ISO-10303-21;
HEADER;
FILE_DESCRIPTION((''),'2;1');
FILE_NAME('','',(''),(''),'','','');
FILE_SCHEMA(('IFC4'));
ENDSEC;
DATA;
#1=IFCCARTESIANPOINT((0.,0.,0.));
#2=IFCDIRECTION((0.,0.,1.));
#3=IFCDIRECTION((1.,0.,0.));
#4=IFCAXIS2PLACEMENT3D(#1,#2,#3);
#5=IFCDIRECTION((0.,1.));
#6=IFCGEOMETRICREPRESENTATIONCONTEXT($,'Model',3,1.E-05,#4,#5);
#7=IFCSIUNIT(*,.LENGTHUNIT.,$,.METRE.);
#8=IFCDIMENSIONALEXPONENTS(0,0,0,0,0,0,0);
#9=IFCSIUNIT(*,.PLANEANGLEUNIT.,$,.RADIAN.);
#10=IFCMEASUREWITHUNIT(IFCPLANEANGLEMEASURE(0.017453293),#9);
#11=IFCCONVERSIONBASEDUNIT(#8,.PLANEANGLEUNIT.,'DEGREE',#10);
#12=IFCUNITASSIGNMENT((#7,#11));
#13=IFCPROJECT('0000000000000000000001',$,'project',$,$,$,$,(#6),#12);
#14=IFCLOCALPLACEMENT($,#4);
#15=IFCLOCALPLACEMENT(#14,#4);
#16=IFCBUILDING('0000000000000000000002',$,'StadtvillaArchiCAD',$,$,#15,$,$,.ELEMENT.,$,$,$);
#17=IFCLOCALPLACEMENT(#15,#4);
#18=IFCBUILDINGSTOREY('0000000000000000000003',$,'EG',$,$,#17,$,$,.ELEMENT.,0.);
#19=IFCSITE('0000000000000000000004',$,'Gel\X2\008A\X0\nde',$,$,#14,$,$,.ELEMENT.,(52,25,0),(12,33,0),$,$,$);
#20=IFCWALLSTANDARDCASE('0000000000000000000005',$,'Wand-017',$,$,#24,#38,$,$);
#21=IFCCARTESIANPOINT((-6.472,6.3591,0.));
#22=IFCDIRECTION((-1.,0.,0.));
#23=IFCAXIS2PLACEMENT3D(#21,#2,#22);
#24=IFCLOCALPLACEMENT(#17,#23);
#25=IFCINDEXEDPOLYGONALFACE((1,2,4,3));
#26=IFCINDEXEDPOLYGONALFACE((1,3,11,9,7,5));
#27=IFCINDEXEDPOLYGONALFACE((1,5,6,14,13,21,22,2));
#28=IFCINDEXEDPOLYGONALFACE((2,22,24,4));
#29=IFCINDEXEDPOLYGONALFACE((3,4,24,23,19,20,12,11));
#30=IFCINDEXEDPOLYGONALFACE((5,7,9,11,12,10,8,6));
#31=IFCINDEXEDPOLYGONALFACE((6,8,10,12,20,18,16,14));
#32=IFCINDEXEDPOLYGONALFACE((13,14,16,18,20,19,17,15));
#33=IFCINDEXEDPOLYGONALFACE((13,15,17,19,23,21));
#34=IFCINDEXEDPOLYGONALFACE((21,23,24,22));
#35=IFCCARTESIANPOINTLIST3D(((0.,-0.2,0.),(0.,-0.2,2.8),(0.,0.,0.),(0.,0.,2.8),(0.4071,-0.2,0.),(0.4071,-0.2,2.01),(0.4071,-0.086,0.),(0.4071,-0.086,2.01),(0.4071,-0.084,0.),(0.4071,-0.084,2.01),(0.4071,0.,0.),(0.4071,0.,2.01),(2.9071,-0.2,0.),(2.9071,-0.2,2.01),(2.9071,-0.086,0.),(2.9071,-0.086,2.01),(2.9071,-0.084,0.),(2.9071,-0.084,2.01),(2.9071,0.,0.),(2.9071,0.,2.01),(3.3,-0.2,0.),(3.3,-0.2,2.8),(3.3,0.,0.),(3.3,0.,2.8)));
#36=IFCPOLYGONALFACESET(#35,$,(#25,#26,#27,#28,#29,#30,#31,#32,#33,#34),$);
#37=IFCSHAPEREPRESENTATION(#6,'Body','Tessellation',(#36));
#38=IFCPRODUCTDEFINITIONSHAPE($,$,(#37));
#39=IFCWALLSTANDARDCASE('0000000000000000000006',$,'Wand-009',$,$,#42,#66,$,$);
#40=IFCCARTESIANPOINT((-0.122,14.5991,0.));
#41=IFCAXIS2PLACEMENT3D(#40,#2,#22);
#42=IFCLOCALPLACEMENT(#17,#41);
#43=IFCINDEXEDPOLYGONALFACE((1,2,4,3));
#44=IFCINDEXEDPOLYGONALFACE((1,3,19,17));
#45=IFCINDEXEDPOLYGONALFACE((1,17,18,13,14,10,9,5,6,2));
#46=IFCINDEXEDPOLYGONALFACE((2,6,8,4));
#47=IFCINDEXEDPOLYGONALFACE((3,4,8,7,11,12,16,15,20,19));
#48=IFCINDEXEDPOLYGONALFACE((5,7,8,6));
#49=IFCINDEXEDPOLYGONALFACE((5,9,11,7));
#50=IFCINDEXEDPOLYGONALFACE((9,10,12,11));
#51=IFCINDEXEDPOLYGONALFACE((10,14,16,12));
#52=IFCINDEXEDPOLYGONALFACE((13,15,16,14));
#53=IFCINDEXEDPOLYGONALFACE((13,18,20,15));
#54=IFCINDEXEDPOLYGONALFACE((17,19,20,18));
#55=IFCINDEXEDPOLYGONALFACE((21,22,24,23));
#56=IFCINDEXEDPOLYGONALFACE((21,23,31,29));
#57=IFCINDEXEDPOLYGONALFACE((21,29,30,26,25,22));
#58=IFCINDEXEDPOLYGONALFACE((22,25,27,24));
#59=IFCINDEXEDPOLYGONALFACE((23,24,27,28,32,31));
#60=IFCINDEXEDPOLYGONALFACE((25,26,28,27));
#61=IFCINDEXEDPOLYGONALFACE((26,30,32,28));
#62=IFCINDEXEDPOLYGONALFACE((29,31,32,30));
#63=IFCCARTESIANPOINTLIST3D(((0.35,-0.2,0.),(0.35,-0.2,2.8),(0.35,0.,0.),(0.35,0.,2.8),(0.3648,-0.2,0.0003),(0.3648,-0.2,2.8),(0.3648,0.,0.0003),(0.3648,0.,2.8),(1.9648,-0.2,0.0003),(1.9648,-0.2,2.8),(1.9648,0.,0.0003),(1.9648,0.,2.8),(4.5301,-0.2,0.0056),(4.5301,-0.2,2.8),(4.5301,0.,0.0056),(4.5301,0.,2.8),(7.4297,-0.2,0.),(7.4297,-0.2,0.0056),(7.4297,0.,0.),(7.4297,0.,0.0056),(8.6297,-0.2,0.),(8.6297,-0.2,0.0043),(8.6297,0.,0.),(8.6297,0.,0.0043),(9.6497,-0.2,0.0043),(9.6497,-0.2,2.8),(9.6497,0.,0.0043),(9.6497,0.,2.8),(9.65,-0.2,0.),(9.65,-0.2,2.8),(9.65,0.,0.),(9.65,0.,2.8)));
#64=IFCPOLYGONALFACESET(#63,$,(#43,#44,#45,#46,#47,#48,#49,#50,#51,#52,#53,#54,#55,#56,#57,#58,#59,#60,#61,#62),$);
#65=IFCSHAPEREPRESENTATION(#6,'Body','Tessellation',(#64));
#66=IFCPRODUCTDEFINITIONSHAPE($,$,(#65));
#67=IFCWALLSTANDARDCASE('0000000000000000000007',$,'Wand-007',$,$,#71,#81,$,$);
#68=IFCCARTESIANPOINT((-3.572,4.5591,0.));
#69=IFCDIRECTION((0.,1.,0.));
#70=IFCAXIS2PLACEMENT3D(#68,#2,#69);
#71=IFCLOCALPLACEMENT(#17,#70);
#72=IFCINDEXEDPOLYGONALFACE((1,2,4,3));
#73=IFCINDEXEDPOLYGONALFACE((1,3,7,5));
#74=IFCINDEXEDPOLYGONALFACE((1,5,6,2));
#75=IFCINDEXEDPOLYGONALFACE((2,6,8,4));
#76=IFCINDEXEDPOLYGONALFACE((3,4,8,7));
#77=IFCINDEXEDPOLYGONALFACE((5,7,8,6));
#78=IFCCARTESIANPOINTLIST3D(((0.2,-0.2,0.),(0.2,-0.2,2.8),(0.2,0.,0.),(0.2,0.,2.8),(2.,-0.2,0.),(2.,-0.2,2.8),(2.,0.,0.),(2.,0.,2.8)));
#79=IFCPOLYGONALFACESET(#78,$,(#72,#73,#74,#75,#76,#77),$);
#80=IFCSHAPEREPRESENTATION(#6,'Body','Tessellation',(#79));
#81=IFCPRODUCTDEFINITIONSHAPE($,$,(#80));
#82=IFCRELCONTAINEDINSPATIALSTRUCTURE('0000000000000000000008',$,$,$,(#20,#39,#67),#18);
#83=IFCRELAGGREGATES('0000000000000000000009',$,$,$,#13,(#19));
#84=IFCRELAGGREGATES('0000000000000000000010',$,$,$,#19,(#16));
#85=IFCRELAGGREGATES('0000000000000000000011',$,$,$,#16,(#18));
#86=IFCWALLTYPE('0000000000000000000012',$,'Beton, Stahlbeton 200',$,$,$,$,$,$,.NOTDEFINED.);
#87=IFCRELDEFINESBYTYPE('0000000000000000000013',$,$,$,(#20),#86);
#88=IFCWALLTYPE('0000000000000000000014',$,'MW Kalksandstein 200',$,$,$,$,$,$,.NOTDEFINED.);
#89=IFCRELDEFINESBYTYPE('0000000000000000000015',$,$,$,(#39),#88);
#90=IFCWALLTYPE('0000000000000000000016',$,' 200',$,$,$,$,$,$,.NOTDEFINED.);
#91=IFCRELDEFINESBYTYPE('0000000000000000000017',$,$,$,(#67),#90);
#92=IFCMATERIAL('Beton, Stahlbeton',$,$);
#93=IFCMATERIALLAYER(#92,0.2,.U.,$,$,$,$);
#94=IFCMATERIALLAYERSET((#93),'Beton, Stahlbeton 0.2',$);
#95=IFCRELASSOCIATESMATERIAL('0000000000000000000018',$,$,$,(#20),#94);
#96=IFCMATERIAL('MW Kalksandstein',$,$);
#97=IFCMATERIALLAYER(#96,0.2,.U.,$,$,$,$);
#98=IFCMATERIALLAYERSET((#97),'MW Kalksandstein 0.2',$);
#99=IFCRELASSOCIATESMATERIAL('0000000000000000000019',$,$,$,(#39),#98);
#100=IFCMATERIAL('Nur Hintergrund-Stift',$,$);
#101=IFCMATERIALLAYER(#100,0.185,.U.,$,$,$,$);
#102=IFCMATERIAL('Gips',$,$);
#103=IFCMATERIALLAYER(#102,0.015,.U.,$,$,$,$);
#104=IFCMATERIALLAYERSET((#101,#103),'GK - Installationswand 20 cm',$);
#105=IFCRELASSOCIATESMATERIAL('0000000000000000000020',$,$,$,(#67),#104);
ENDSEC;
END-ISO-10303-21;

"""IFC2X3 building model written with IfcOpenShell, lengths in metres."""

from ifc_helpers import new_model, entity, si_unit, converted_unit, direction, frame, origin_with_axes, origin_2d_with_axis, place, context, project, spatial, polyline, rectangle, outline, extrude, material, layer, layer_set, layer_usage, type_object, element, save


model = new_model("IFC2X3")

# Units and contexts
model_context = context("Model", 3, precision=1e-05, world=origin_with_axes(), true_north=direction((0.0, 1.0)))
ifc_project = project(units=[si_unit("LENGTHUNIT", "METRE"), converted_unit("PLANEANGLEUNIT", "DEGREE", entity("IfcPlaneAngleMeasure", 0.017453293), si_unit("PLANEANGLEUNIT", "RADIAN"), dimensions=[0, 0, 0, 0, 0, 0, 0])], contexts=[model_context])

# Site, building, storey
site_placement = place(None, origin_with_axes())
site = spatial("IfcSite", under=ifc_project, at=site_placement, Name="Gel\u008ande", CompositionType="ELEMENT", RefLatitude=(52, 25, 0), RefLongitude=(12, 33, 0))
building_placement = place(site_placement, origin_with_axes())
building = spatial("IfcBuilding", under=site, at=building_placement, Name="StadtvillaArchiCAD", CompositionType="ELEMENT")
storey_placement = place(building_placement, origin_with_axes())
storey = spatial("IfcBuildingStorey", under=building, at=storey_placement, Name="EG", CompositionType="ELEMENT", Elevation=0.0)

# Shared definitions
ifc_material_1 = material(Name="Beton, Stahlbeton")

# Shared definitions
ifc_layer_1 = layer(ifc_material_1, 0.2, ventilated="UNKNOWN")
ifc_layer_set_1 = layer_set([ifc_layer_1], Name="Beton, Stahlbeton 0.2")
wall_type_1 = type_object("IfcWallType", Name="Beton, Stahlbeton 200", PredefinedType="NOTDEFINED")

# Wall, opening
ifc_layer_usage_1 = layer_usage(ifc_layer_set_1, "AXIS2", "NEGATIVE", 0.0)
wall_1_placement = place(storey_placement, frame((-6.472, 6.3591, 0.0), z_axis=(0.0, 0.0, 1.0), x_axis=(-1.0, 0.0, 0.0)))
wall_1 = element("IfcWallStandardCase", 1, at=wall_1_placement, inside=storey, type_object=wall_type_1, material=ifc_layer_usage_1, Name="Wand-017", context=model_context, shape_type="SweptSolid", body=[
    extrude(outline(polyline([(0.0, -0.2), (3.3, -0.2), (3.3, 0.0), (0.0, 0.0), (0.0, -0.2)])), origin_with_axes(), (0.0, 0.0, 1.0), 2.8),
])
opening_1_placement = place(wall_1_placement, frame((1.6571, 0.0, 0.0), z_axis=(0.0, 0.0, 1.0), x_axis=(1.0, 0.0, 0.0)))
element("IfcOpeningElement", 2, at=opening_1_placement, cuts=wall_1, context=model_context, shape_type="SweptSolid", body=[
    extrude(rectangle(XDim=2.5, YDim=2.01, at=origin_2d_with_axis()), frame((0.0, -0.601, 1.005), z_axis=(0.0, 1.0, 0.0), x_axis=(1.0, 0.0, 0.0)), (0.0, 0.0, 1.0), 0.517),
    extrude(rectangle(XDim=2.5, YDim=2.01, at=origin_2d_with_axis()), frame((0.0, 0.401, 1.005), z_axis=(0.0, -1.0, 0.0), x_axis=(1.0, 0.0, 0.0)), (0.0, 0.0, 1.0), 0.487),
])

# Wall, openings
ifc_material_2 = material(Name="MW Kalksandstein")
ifc_layer_2 = layer(ifc_material_2, 0.2, ventilated="UNKNOWN")
ifc_layer_set_2 = layer_set([ifc_layer_2], Name="MW Kalksandstein 0.2")
ifc_layer_usage_2 = layer_usage(ifc_layer_set_2, "AXIS2", "NEGATIVE", 0.0)
wall_type_2 = type_object("IfcWallType", Name="MW Kalksandstein 200", PredefinedType="NOTDEFINED")
wall_2_placement = place(storey_placement, frame((-0.122, 14.5991, 0.0), z_axis=(0.0, 0.0, 1.0), x_axis=(-1.0, 0.0, 0.0)))
wall_2 = element("IfcWallStandardCase", 3, at=wall_2_placement, inside=storey, type_object=wall_type_2, material=ifc_layer_usage_2, Name="Wand-009", context=model_context, shape_type="SweptSolid", body=[
    extrude(outline(polyline([(0.35, -0.2), (9.65, -0.2), (9.65, 0.0), (0.35, 0.0), (0.35, -0.2)])), origin_with_axes(), (0.0, 0.0, 1.0), 2.8),
])
opening_2_placement = place(wall_2_placement, frame((9.1397, 0.0, 0.0043), z_axis=(0.0, 0.0, 1.0), x_axis=(1.0, 0.0, 0.0)))
element("IfcOpeningElement", 4, at=opening_2_placement, cuts=wall_2, context=model_context, shape_type="SweptSolid", body=[
    extrude(rectangle(XDim=1.02, YDim=2.8, at=origin_2d_with_axis()), frame((0.0, 0.001, 1.4), z_axis=(0.0, -1.0, 0.0), x_axis=(1.0, 0.0, 0.0)), (0.0, 0.0, 1.0), 0.602),
])
opening_3_placement = place(wall_2_placement, frame((8.0297, 0.0, 0.0), z_axis=(0.0, 0.0, 1.0), x_axis=(1.0, 0.0, 0.0)))
element("IfcOpeningElement", 5, at=opening_3_placement, cuts=wall_2, context=model_context, shape_type="SweptSolid", body=[
    extrude(rectangle(XDim=1.2, YDim=2.8, at=origin_2d_with_axis()), frame((0.0, 0.001, 1.4), z_axis=(0.0, -1.0, 0.0), x_axis=(1.0, 0.0, 0.0)), (0.0, 0.0, 1.0), 0.602),
])
opening_4_placement = place(wall_2_placement, frame((5.9801, 0.0, 0.0056), z_axis=(0.0, 0.0, 1.0), x_axis=(1.0, 0.0, 0.0)))
element("IfcOpeningElement", 6, at=opening_4_placement, cuts=wall_2, context=model_context, shape_type="SweptSolid", body=[
    extrude(rectangle(XDim=2.9, YDim=2.8, at=origin_2d_with_axis()), frame((0.0, 0.001, 1.4), z_axis=(0.0, -1.0, 0.0), x_axis=(1.0, 0.0, 0.0)), (0.0, 0.0, 1.0), 0.602),
])
opening_5_placement = place(wall_2_placement, frame((1.1648, 0.0, 0.0003), z_axis=(0.0, 0.0, 1.0), x_axis=(1.0, 0.0, 0.0)))
element("IfcOpeningElement", 7, at=opening_5_placement, cuts=wall_2, context=model_context, shape_type="SweptSolid", body=[
    extrude(rectangle(XDim=1.6, YDim=2.8, at=origin_2d_with_axis()), frame((0.0, 0.001, 1.4), z_axis=(0.0, -1.0, 0.0), x_axis=(1.0, 0.0, 0.0)), (0.0, 0.0, 1.0), 0.602),
])

# Wall
ifc_material_3 = material(Name="Nur Hintergrund-Stift")
ifc_layer_3 = layer(ifc_material_3, 0.185, ventilated="UNKNOWN")
ifc_material_4 = material(Name="Gips")
ifc_layer_4 = layer(ifc_material_4, 0.015, ventilated="UNKNOWN")
ifc_layer_set_3 = layer_set([ifc_layer_3, ifc_layer_4], Name="GK - Installationswand 20 cm")
ifc_layer_usage_3 = layer_usage(ifc_layer_set_3, "AXIS2", "NEGATIVE", 0.0)
wall_type_3 = type_object("IfcWallType", Name=" 200", PredefinedType="NOTDEFINED")
wall_3_placement = place(storey_placement, frame((-3.572, 4.5591, 0.0), z_axis=(0.0, 0.0, 1.0), x_axis=(0.0, 1.0, 0.0)))
element("IfcWallStandardCase", 8, at=wall_3_placement, inside=storey, type_object=wall_type_3, material=ifc_layer_usage_3, Name="Wand-007", context=model_context, shape_type="SweptSolid", body=[
    extrude(outline(polyline([(0.2, -0.2), (2.0, -0.2), (2.0, 0.0), (0.2, 0.0), (0.2, -0.2)])), origin_with_axes(), (0.0, 0.0, 1.0), 2.8),
])

save(model, "model.ifc")
